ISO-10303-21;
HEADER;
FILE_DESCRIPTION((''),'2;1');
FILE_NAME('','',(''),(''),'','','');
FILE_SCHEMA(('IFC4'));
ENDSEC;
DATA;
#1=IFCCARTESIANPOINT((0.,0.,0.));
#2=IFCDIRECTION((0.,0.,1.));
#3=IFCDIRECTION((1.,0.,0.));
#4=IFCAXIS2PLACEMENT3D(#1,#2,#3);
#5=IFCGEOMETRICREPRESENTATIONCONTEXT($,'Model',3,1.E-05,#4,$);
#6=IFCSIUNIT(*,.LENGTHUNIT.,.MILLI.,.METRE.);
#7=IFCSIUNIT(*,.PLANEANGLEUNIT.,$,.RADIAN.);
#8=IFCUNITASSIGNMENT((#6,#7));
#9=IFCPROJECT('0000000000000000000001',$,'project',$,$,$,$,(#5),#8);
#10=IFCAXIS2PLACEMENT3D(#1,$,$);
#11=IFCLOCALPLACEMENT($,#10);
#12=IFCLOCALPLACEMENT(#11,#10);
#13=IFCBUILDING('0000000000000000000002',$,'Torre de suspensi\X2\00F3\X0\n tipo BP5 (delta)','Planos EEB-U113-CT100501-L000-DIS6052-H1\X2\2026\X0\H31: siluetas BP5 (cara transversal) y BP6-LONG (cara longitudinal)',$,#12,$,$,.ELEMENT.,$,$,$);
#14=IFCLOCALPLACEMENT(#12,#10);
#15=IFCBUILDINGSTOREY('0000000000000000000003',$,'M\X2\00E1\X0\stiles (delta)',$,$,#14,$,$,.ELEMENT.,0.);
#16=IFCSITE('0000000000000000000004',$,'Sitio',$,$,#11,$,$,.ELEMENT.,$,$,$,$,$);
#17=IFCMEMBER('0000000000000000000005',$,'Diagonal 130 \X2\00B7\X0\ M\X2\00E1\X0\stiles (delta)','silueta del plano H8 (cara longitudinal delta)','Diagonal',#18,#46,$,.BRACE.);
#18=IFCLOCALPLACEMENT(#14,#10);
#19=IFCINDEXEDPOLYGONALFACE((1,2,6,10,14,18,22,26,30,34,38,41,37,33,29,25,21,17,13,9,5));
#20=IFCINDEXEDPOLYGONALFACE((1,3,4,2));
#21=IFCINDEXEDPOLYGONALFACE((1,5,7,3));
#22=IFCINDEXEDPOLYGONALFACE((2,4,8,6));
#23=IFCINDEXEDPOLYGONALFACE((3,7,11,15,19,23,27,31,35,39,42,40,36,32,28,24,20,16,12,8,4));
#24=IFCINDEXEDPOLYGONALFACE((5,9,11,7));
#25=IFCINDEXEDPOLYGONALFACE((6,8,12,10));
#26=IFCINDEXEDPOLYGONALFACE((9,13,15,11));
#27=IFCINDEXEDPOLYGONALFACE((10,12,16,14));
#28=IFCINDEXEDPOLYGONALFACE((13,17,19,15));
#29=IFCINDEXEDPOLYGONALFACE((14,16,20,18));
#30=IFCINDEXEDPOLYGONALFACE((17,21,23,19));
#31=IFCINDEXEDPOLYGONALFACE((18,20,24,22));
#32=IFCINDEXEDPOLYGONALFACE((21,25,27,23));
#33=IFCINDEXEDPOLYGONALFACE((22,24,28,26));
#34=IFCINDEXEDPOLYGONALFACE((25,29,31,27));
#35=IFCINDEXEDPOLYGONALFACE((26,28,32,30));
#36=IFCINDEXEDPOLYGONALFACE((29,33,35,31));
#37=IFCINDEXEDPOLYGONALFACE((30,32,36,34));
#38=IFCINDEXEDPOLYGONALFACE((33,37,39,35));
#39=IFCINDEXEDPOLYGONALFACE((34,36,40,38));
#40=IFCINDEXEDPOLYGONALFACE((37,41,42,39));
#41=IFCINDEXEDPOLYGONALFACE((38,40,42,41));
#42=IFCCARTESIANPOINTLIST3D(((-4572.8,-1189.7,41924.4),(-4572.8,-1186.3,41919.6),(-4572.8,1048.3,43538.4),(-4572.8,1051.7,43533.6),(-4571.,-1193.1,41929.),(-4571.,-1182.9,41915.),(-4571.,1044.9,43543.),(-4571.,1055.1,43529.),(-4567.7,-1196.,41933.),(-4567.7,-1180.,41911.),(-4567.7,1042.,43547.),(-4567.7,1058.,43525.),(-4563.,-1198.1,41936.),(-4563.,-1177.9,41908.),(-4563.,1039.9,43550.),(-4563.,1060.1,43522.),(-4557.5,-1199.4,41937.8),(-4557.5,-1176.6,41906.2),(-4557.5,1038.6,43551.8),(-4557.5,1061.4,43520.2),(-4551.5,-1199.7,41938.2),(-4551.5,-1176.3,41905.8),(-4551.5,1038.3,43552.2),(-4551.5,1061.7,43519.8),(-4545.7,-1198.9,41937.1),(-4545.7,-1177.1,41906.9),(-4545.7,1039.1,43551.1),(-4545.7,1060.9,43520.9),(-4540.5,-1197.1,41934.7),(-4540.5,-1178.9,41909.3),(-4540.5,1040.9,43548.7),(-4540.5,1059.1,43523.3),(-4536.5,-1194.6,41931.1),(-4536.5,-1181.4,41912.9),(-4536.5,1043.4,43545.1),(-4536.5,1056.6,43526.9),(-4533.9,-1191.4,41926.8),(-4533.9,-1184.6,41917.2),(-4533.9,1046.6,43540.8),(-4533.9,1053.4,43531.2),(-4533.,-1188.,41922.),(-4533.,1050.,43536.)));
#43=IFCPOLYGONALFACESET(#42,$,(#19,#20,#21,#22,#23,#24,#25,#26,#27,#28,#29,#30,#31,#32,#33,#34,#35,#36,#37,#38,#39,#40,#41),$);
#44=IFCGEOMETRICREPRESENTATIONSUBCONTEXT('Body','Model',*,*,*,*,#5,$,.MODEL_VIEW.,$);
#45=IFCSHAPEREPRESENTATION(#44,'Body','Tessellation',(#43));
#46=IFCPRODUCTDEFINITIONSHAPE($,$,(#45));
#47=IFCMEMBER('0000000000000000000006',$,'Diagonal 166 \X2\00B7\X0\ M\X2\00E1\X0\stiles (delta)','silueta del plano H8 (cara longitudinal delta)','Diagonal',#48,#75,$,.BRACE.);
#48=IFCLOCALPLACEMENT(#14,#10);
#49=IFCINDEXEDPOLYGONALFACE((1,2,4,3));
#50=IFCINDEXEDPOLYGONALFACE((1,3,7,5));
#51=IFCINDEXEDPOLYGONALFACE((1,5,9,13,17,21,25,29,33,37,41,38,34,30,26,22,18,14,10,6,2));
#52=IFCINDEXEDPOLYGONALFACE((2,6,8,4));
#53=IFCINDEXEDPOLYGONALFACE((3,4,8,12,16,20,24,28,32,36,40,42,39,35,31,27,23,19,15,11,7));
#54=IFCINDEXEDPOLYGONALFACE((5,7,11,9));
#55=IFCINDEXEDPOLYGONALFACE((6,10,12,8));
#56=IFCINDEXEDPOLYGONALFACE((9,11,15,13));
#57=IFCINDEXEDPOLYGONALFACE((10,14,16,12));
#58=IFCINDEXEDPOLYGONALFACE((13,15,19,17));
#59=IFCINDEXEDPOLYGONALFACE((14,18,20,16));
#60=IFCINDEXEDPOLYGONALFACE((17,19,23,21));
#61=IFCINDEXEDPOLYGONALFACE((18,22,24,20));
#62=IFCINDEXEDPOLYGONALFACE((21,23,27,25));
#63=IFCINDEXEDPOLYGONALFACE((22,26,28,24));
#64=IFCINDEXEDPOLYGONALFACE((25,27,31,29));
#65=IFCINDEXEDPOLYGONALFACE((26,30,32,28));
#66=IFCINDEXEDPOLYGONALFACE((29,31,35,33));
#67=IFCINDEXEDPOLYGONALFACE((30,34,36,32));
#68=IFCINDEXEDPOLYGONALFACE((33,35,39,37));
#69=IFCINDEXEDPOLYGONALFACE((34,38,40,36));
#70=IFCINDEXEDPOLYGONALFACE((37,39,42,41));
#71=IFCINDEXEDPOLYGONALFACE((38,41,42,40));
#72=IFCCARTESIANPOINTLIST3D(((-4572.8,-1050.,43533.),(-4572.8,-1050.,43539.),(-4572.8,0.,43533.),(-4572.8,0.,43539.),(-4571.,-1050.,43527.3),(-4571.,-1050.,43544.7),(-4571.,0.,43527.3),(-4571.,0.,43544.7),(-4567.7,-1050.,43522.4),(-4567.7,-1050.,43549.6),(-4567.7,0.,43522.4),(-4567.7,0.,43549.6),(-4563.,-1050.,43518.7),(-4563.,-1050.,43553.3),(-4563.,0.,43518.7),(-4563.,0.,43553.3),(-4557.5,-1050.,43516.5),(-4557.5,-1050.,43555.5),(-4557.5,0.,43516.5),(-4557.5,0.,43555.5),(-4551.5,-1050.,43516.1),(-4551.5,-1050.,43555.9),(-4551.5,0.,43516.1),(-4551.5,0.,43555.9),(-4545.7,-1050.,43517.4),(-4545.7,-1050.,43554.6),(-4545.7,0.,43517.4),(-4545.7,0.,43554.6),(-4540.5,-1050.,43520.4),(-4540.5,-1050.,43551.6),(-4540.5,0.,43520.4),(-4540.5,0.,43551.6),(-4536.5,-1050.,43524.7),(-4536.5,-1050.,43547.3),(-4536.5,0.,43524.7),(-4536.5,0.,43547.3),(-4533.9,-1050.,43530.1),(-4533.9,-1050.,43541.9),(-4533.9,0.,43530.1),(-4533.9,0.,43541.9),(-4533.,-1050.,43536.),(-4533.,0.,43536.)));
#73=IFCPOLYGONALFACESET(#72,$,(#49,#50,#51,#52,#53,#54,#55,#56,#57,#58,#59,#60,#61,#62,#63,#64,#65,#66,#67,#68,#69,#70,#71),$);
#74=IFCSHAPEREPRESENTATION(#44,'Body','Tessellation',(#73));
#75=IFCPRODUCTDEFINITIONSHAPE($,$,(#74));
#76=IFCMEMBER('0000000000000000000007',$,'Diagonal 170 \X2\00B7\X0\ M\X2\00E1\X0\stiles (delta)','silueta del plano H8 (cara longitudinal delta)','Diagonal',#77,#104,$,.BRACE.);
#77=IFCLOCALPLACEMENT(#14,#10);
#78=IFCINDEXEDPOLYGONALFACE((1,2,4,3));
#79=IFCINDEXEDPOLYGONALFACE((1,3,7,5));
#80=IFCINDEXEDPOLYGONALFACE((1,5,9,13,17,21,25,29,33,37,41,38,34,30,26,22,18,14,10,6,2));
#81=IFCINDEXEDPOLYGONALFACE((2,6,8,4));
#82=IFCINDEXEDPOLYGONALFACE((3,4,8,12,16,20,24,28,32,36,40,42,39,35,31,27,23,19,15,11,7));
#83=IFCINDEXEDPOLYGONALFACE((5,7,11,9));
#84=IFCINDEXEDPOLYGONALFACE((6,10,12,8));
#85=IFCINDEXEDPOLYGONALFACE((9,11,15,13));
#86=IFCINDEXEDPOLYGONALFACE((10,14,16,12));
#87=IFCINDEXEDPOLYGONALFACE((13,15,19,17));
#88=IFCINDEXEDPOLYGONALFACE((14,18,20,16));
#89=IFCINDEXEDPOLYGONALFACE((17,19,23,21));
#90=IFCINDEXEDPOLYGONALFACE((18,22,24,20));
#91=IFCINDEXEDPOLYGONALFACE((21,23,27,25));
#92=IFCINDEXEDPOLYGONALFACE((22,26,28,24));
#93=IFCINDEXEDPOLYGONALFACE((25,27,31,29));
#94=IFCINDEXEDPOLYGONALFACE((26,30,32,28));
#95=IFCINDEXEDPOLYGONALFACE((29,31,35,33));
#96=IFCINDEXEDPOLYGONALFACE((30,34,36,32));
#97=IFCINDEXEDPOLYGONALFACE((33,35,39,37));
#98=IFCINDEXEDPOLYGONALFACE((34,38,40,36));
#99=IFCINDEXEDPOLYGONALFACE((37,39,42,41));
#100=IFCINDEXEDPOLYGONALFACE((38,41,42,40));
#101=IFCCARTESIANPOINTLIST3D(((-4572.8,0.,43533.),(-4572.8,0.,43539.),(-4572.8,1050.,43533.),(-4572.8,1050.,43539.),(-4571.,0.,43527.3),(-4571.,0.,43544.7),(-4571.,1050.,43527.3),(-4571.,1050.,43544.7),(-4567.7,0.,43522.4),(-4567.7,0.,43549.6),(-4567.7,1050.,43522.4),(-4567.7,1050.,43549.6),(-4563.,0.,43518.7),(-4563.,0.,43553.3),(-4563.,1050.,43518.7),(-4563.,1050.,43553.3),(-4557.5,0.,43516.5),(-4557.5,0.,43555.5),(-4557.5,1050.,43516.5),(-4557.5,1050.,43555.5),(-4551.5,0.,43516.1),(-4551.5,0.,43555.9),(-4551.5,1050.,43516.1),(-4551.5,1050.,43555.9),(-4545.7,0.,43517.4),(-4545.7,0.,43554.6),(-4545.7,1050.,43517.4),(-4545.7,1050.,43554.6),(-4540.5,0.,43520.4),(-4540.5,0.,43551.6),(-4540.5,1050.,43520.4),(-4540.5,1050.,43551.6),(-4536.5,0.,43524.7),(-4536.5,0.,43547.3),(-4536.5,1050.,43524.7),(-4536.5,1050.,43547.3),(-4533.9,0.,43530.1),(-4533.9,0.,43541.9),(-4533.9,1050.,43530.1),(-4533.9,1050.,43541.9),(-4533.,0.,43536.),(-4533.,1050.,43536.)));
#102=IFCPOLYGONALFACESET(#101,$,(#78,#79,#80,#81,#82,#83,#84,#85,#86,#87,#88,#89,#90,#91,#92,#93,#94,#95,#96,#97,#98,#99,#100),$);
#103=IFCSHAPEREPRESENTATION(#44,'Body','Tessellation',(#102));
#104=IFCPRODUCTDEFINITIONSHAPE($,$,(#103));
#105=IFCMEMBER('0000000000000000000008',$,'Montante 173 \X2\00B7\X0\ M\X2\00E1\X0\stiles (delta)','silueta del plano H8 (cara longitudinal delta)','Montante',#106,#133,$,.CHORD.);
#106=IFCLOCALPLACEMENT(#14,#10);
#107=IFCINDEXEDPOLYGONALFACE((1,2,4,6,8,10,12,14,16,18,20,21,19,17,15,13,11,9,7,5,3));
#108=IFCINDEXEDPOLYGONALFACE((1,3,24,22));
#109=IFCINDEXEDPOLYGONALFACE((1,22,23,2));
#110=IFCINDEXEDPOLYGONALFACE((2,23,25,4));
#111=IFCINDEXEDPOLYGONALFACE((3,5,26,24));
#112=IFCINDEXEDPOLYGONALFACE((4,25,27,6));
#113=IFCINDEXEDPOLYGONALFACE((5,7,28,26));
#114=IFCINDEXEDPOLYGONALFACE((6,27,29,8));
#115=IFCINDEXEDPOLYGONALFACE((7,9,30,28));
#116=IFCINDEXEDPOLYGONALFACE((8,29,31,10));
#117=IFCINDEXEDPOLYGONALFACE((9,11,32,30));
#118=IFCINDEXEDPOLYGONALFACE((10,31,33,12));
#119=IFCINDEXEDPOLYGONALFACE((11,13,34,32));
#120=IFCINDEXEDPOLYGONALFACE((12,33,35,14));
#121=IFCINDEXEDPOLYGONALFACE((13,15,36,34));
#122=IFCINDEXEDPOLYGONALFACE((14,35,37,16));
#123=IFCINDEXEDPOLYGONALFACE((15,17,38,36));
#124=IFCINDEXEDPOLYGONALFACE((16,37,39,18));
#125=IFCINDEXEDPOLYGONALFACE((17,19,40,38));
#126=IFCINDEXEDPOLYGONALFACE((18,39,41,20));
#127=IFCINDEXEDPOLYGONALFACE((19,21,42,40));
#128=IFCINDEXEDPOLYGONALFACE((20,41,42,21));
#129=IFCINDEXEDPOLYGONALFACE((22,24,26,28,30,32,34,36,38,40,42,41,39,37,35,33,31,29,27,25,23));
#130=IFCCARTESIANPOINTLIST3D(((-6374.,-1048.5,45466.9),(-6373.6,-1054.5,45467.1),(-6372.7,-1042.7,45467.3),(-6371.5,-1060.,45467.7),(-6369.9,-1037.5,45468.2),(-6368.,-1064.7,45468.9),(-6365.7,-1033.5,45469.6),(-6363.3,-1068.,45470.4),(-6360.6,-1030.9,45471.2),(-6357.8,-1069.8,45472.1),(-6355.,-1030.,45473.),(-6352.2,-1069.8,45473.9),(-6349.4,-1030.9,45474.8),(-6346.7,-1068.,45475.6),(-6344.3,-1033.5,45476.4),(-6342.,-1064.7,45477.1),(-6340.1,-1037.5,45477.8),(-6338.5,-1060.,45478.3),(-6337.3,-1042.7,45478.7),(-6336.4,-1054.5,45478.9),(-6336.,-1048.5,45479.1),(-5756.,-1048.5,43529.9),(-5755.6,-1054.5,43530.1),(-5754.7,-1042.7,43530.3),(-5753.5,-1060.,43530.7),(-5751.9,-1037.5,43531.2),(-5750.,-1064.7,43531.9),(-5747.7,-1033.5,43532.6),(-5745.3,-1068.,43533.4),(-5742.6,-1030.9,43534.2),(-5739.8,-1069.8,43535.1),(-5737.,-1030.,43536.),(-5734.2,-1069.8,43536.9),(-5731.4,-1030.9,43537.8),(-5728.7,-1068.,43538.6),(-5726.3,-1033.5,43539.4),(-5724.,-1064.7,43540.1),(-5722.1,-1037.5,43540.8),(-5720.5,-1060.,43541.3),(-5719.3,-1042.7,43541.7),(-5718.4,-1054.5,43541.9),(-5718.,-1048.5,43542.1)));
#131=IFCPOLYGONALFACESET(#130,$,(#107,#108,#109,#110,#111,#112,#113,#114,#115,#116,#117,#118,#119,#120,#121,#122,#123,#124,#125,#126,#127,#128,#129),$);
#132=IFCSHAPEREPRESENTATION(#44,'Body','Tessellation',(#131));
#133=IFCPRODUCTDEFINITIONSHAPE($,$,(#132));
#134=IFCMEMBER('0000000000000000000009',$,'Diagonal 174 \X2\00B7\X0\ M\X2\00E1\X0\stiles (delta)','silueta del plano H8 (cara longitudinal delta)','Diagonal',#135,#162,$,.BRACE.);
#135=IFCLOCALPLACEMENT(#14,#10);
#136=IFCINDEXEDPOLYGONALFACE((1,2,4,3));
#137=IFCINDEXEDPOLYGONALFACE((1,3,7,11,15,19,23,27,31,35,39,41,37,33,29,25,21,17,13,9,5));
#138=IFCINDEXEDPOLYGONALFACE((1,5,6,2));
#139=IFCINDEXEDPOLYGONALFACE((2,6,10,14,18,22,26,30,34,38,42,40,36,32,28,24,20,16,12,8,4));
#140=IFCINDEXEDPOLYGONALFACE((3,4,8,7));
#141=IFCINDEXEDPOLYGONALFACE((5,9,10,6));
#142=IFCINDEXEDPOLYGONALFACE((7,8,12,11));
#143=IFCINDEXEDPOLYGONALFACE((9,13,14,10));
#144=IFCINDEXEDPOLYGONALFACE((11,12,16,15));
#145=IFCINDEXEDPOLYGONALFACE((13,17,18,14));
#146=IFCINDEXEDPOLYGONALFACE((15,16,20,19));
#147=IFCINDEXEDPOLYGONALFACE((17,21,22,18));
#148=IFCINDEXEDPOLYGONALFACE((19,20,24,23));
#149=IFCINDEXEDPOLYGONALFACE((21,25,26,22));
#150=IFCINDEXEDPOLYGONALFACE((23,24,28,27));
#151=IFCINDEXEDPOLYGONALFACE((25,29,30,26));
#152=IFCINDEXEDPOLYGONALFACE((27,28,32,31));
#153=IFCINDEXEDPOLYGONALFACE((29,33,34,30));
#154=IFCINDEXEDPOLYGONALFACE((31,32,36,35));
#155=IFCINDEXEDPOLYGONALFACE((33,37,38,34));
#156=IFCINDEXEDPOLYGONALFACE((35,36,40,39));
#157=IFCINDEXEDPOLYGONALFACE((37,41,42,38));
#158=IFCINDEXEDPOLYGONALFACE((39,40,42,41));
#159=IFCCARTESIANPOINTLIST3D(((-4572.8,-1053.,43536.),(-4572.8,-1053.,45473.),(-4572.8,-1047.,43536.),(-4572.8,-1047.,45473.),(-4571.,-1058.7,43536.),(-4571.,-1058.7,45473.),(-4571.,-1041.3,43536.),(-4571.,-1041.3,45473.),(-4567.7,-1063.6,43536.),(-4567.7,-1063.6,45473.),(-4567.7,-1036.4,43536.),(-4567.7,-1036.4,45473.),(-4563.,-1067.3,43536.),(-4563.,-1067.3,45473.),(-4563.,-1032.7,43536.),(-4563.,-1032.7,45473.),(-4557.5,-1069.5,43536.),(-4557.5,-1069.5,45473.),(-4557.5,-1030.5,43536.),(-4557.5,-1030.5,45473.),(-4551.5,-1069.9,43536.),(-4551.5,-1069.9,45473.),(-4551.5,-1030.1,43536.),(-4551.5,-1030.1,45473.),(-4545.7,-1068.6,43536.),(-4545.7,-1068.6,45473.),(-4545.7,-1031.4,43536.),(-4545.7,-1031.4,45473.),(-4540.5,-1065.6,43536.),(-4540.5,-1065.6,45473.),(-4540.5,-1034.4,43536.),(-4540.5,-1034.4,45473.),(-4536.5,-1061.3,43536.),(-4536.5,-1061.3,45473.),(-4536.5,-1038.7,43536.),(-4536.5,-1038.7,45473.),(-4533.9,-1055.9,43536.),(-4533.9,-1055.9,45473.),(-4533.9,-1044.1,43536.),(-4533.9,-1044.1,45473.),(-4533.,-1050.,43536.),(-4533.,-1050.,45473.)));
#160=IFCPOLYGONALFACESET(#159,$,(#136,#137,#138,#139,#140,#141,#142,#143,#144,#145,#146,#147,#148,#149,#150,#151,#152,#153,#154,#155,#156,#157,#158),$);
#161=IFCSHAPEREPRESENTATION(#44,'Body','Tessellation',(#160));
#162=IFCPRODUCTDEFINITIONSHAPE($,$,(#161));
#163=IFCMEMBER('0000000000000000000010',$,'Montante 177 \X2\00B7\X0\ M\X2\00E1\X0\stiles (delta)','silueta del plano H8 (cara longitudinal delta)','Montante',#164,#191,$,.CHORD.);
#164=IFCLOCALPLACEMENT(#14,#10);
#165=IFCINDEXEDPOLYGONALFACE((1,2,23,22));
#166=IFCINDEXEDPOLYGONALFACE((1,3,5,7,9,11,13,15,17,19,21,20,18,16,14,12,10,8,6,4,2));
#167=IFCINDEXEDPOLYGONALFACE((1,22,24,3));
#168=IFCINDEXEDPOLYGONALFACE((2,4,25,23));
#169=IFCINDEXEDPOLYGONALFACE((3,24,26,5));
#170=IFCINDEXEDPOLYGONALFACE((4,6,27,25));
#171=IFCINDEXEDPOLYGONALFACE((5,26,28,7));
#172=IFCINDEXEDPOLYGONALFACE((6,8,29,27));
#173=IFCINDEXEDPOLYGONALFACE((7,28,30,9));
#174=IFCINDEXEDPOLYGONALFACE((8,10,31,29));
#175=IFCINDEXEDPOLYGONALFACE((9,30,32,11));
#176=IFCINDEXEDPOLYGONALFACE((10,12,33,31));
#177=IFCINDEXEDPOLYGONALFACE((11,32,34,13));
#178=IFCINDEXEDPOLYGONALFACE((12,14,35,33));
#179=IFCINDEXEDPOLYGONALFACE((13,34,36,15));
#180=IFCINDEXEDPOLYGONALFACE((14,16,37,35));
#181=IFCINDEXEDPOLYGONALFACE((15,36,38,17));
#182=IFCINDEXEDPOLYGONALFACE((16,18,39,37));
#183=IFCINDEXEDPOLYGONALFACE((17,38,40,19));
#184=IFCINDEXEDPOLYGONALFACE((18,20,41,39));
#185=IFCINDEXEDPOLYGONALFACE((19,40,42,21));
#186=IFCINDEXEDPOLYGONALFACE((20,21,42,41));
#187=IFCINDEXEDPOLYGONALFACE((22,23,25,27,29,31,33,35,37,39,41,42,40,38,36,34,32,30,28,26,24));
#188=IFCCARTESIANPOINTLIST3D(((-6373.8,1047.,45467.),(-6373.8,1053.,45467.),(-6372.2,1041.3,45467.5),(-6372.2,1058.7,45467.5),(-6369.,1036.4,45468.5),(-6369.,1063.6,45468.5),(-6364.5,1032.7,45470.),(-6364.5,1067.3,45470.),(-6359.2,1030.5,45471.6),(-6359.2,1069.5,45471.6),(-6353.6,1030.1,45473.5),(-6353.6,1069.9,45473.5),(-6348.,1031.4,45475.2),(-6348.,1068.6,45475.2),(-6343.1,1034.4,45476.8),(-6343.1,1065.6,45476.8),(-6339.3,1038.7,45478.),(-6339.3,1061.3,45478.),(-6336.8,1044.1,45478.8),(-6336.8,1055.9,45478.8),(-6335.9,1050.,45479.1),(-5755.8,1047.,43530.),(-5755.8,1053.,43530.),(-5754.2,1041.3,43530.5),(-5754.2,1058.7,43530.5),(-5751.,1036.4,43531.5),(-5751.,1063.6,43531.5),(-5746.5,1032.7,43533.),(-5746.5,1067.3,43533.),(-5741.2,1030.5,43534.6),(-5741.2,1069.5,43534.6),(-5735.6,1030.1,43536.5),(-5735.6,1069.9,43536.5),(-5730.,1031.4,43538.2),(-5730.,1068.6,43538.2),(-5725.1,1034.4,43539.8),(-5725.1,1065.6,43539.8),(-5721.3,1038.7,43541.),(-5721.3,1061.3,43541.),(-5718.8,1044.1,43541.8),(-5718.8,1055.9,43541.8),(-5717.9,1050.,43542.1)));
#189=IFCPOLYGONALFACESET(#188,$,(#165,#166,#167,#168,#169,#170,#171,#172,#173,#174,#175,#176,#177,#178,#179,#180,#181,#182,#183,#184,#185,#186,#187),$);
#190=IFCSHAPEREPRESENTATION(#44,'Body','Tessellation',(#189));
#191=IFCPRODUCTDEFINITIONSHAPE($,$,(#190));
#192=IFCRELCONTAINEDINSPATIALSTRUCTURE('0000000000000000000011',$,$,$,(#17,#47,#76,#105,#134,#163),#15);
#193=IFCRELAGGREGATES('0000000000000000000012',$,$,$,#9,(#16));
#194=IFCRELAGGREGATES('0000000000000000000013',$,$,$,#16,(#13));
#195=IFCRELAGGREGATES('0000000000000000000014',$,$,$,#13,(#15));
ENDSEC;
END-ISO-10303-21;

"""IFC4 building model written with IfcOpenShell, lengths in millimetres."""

from ifc_helpers import new_model, si_unit, frame, origin, origin_with_axes, place, context, subcontext, project, spatial, circle, extrude, element, save


model = new_model("IFC4")

# Units and contexts
model_context = context("Model", 3, precision=1e-05, world=origin_with_axes())
body_context = subcontext(model_context, "Body", "Model", "MODEL_VIEW")
ifc_project = project(units=[si_unit("LENGTHUNIT", "METRE", prefix="MILLI"), si_unit("PLANEANGLEUNIT", "RADIAN")], contexts=[model_context])

# Site, building, storey
site_placement = place(None, origin())
site = spatial("IfcSite", under=ifc_project, at=site_placement, Name="Sitio", CompositionType="ELEMENT")
building_placement = place(site_placement, origin())
building = spatial("IfcBuilding", under=site, at=building_placement, Name="Torre de suspensión tipo BP5 (delta)", Description="Planos EEB-U113-CT100501-L000-DIS6052-H1…H31: siluetas BP5 (cara transversal) y BP6-LONG (cara longitudinal)", CompositionType="ELEMENT")
storey_placement = place(building_placement, origin())
storey = spatial("IfcBuildingStorey", under=building, at=storey_placement, Name="Mástiles (delta)", CompositionType="ELEMENT", Elevation=0.0)

# Members
member_1_placement = place(storey_placement, frame((-4553.0, 1050.0, 43536.0), z_axis=(0.0, -0.81108, -0.584935), x_axis=(1.0, 0.0, 0.0)))
element("IfcMember", 1, at=member_1_placement, inside=storey, Name="Diagonal 130 · Mástiles (delta)", Description="silueta del plano H8 (cara longitudinal delta)", ObjectType="Diagonal", PredefinedType="BRACE", context=body_context, shape_type="SweptSolid", body=[
    extrude(circle(Radius=20.0), None, (0.0, 0.0, 1.0), 2759.3),
])
for number, where, z_axis, x_axis, name in (
    (2, (-4553.0, -1050.0, 43536.0), (0.0, 1.0, 0.0), (1.0, 0.0, 0.0), "Diagonal 166 · Mástiles (delta)"),
    (3, (-4553.0, 1050.0, 43536.0), (0.0, -1.0, 0.0), (1.0, 0.0, 0.0), "Diagonal 170 · Mástiles (delta)"),
):
    element("IfcMember", number, at=place(storey_placement, frame(where, z_axis=z_axis, x_axis=x_axis)), inside=storey, Name=name, Description="silueta del plano H8 (cara longitudinal delta)", ObjectType="Diagonal", PredefinedType="BRACE", context=body_context, shape_type="SweptSolid", body=[
        extrude(circle(Radius=20.0), None, (0.0, 0.0, 1.0), 1050.0),
    ])
member_2_placement = place(storey_placement, frame((-6355.0, -1050.0, 45473.0), z_axis=(0.303955, 0.0, -0.952686), x_axis=(0.0, 1.0, 0.0)))
element("IfcMember", 4, at=member_2_placement, inside=storey, Name="Montante 173 · Mástiles (delta)", Description="silueta del plano H8 (cara longitudinal delta)", ObjectType="Montante", PredefinedType="CHORD", context=body_context, shape_type="SweptSolid", body=[
    extrude(circle(Radius=20.0), None, (0.0, 0.0, 1.0), 2033.2),
])
member_3_placement = place(storey_placement, frame((-4553.0, -1050.0, 45473.0), z_axis=(0.0, 0.0, -1.0), x_axis=(1.0, 0.0, 0.0)))
element("IfcMember", 5, at=member_3_placement, inside=storey, Name="Diagonal 174 · Mástiles (delta)", Description="silueta del plano H8 (cara longitudinal delta)", ObjectType="Diagonal", PredefinedType="BRACE", context=body_context, shape_type="SweptSolid", body=[
    extrude(circle(Radius=20.0), None, (0.0, 0.0, 1.0), 1937.0),
])
member_4_placement = place(storey_placement, frame((-6355.0, 1050.0, 45473.0), z_axis=(0.303955, 0.0, -0.952686), x_axis=(0.952686, 0.0, 0.303955)))
element("IfcMember", 6, at=member_4_placement, inside=storey, Name="Montante 177 · Mástiles (delta)", Description="silueta del plano H8 (cara longitudinal delta)", ObjectType="Montante", PredefinedType="CHORD", context=body_context, shape_type="SweptSolid", body=[
    extrude(circle(Radius=20.0), None, (0.0, 0.0, 1.0), 2033.2),
])

save(model, "model.ifc")
